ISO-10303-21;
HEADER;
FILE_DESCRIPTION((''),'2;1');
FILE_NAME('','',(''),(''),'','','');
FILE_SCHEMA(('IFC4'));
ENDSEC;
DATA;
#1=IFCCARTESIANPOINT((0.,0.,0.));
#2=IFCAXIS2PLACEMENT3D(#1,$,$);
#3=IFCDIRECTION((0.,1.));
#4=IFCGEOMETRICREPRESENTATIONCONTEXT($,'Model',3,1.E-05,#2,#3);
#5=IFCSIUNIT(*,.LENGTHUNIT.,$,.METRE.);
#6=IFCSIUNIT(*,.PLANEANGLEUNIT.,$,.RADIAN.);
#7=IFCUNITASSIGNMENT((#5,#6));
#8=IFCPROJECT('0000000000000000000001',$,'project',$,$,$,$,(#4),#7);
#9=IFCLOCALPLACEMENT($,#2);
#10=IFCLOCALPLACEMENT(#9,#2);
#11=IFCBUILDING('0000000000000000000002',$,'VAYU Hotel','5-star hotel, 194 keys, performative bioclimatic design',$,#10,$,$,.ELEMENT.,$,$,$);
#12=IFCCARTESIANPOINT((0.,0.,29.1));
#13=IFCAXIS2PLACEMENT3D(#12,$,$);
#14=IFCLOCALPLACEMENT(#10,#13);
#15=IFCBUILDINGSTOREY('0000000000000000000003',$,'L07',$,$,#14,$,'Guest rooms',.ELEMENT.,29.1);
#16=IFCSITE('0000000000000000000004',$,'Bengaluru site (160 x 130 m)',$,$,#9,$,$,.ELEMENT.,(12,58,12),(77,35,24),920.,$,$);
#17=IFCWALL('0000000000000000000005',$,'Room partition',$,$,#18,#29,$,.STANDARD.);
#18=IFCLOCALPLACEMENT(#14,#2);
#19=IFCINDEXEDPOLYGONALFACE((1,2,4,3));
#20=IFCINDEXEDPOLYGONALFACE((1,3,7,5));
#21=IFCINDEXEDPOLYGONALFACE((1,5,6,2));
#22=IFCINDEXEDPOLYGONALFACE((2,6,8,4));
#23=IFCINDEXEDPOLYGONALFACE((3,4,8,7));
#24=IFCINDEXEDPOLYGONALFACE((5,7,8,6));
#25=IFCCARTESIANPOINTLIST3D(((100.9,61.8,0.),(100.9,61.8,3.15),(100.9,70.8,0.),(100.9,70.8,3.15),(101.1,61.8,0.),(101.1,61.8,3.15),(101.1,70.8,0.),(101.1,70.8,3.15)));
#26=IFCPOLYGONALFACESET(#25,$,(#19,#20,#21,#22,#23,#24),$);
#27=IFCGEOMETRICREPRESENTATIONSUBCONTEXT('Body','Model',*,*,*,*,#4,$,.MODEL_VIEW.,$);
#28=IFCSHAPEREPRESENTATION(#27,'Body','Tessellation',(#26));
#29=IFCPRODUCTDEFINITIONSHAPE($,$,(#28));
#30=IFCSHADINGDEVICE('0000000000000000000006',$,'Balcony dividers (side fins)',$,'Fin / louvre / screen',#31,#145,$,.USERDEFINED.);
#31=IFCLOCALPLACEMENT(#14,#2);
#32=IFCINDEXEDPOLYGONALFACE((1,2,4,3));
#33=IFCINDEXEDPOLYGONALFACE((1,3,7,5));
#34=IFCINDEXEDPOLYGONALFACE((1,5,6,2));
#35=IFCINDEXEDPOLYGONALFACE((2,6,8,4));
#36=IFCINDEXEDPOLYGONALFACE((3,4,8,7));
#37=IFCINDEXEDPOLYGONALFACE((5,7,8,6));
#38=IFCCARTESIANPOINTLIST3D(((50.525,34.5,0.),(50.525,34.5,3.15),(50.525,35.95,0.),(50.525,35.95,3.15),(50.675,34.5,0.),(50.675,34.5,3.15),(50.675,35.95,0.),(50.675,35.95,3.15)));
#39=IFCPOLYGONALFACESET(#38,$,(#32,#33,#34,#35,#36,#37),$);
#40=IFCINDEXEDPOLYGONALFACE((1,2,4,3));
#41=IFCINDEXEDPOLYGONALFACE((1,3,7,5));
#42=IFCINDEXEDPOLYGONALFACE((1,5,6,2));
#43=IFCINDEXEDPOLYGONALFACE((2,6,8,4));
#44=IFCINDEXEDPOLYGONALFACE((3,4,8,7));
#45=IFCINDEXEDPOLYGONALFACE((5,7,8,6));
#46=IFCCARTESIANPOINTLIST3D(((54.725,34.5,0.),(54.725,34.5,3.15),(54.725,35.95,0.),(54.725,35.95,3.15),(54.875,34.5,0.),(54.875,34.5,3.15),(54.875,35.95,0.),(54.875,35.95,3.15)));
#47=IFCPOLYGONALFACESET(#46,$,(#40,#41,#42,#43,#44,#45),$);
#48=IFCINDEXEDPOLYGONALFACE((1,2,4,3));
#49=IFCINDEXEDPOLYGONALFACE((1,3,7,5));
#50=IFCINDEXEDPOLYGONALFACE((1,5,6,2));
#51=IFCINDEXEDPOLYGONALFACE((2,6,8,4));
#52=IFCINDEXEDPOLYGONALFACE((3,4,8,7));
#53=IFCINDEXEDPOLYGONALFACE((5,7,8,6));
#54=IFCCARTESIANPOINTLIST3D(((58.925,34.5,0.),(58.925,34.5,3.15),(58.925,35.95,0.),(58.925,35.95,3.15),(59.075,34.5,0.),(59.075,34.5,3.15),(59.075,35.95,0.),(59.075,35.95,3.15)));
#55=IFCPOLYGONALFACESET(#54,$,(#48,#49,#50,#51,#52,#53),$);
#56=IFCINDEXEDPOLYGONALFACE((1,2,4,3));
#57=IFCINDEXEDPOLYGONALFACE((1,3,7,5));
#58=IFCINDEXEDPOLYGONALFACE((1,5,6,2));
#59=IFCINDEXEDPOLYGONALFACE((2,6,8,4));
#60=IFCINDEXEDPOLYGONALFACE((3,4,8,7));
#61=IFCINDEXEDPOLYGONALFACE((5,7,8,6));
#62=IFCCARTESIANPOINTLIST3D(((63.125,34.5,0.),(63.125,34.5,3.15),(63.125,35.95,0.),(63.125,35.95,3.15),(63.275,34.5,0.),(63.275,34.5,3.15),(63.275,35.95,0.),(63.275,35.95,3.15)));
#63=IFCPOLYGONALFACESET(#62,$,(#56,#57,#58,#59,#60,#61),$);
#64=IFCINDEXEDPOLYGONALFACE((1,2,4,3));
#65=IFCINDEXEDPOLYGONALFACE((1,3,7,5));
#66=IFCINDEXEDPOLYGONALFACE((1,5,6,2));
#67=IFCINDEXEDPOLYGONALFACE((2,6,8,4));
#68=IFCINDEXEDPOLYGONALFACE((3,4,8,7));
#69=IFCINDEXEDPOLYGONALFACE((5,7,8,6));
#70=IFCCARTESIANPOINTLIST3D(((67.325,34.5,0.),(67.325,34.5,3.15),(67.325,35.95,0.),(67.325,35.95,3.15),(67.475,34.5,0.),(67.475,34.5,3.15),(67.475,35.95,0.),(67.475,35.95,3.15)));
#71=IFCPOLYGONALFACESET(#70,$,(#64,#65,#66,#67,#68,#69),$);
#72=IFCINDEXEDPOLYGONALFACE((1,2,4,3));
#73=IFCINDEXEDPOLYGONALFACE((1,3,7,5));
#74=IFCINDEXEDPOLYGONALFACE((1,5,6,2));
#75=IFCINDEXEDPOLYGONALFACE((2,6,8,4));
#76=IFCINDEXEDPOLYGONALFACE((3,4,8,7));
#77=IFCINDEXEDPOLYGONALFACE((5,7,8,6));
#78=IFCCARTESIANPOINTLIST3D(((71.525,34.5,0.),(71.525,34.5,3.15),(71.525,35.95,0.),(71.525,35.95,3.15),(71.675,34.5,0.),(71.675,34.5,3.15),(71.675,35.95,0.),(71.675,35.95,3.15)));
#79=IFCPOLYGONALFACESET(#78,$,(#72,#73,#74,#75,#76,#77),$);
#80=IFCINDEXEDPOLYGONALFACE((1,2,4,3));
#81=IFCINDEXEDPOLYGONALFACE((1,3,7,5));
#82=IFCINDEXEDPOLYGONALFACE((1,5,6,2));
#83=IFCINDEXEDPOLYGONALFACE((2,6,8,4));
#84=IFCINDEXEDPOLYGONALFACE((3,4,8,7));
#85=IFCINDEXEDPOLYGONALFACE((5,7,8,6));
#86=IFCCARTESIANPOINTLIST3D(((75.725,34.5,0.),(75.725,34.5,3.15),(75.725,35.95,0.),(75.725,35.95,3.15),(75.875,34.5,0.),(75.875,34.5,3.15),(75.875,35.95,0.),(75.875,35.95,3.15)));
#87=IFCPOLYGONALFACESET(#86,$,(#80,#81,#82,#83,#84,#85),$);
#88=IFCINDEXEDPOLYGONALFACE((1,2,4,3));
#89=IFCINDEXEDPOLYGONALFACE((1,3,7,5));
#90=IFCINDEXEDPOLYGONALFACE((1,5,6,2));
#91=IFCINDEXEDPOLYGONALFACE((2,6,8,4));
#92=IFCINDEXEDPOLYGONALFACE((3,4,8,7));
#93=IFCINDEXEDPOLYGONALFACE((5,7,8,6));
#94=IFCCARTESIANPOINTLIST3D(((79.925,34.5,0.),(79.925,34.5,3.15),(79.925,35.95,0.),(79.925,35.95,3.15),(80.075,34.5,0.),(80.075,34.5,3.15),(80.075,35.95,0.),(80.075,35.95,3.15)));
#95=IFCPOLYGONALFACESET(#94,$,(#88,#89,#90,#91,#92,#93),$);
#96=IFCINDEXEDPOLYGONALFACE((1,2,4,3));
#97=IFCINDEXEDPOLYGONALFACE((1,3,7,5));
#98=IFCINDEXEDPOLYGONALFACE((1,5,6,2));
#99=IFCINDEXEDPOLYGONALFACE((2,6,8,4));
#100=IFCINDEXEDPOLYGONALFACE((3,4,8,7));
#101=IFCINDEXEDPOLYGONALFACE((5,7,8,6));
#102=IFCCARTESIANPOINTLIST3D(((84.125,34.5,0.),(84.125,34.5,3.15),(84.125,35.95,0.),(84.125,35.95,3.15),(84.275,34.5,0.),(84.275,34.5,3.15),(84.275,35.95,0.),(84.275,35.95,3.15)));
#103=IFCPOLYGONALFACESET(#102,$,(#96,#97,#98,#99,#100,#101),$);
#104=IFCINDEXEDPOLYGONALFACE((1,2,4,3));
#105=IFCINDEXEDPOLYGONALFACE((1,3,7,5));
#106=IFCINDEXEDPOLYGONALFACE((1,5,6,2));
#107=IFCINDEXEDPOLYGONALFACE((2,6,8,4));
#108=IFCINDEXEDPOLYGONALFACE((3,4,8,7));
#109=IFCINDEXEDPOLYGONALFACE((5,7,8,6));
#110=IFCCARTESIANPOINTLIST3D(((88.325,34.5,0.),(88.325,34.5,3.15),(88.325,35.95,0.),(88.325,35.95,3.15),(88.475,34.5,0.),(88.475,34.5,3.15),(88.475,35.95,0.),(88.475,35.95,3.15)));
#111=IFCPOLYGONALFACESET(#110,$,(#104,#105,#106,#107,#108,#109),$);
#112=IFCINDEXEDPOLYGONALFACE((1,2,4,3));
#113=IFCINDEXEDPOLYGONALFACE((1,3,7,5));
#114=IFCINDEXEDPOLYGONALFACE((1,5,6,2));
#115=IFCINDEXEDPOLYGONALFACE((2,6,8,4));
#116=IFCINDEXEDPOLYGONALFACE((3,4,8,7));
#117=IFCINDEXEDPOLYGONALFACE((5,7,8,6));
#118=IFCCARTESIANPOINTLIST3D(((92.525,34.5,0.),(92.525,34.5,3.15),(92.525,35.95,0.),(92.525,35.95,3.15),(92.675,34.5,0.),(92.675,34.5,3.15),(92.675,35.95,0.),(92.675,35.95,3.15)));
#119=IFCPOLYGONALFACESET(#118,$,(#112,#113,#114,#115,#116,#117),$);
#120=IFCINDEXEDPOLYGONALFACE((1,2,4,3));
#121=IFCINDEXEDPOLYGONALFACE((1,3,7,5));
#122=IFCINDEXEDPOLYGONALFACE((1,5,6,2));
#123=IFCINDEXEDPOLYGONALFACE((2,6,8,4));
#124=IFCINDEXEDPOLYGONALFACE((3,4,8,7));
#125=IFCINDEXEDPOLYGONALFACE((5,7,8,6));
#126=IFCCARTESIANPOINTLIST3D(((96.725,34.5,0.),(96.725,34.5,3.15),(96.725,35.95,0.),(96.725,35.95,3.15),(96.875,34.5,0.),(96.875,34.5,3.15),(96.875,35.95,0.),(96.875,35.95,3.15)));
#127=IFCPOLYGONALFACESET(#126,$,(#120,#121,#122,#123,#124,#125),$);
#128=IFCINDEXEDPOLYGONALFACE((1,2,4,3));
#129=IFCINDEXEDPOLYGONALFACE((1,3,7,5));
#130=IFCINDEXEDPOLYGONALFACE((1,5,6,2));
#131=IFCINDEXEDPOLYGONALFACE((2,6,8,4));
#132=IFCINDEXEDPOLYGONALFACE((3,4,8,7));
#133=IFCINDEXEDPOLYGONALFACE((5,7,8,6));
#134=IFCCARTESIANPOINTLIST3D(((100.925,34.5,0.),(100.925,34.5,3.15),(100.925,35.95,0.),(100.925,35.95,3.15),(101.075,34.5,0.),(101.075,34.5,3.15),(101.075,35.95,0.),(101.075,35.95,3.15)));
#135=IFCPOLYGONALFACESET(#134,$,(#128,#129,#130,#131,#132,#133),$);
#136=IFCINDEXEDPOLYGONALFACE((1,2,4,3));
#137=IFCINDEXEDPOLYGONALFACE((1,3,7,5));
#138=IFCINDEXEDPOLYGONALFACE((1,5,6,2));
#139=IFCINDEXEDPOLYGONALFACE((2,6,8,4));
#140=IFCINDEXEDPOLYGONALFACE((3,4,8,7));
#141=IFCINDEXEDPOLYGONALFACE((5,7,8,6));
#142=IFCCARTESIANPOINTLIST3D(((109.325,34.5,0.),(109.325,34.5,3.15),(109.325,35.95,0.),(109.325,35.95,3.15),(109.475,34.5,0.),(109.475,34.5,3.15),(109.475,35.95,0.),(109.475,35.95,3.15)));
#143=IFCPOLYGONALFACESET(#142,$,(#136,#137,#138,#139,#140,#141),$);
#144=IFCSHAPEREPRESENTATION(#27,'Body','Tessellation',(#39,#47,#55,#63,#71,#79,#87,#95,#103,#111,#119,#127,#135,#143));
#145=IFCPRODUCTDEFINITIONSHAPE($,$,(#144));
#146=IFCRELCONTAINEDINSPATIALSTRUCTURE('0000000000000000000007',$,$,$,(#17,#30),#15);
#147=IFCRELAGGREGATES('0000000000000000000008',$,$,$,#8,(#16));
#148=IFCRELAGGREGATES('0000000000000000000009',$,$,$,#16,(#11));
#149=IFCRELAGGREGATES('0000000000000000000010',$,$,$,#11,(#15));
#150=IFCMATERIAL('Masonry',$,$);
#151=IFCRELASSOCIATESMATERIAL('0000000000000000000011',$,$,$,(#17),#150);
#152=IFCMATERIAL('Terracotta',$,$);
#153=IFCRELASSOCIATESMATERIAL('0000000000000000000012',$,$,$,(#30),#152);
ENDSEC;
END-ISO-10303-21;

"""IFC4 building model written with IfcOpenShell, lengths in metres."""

from ifc_helpers import new_model, si_unit, direction, frame, origin, place, context, subcontext, project, spatial, polyline, outline, extrude, material, element, save


model = new_model("IFC4")

# Units and contexts
model_context = context("Model", 3, precision=1e-05, world=origin(), true_north=direction((0.0, 1.0)))
body_context = subcontext(model_context, "Body", "Model", "MODEL_VIEW")
ifc_project = project(units=[si_unit("LENGTHUNIT", "METRE"), si_unit("PLANEANGLEUNIT", "RADIAN")], contexts=[model_context])

# Site, building, storey
site_placement = place(None, origin())
site = spatial("IfcSite", under=ifc_project, at=site_placement, Name="Bengaluru site (160 x 130 m)", CompositionType="ELEMENT", RefLatitude=(12, 58, 12), RefLongitude=(77, 35, 24), RefElevation=920.0)
building_placement = place(site_placement, origin())
building = spatial("IfcBuilding", under=site, at=building_placement, Name="VAYU Hotel", Description="5-star hotel, 194 keys, performative bioclimatic design", CompositionType="ELEMENT")
storey_placement = place(building_placement, frame((0.0, 0.0, 29.1)))
storey = spatial("IfcBuildingStorey", under=building, at=storey_placement, Name="L07", LongName="Guest rooms", CompositionType="ELEMENT", Elevation=29.1)

# Wall
ifc_material_1 = material(Name="Masonry")
wall_1_placement = place(storey_placement, origin())
element("IfcWall", 1, at=wall_1_placement, inside=storey, material=ifc_material_1, Name="Room partition", PredefinedType="STANDARD", context=body_context, shape_type="SweptSolid", body=[
    extrude(outline(polyline([(100.9, 61.8), (100.9, 70.8), (101.1, 70.8), (101.1, 61.8), (100.9, 61.8)])), origin(), (0.0, 0.0, 1.0), 3.15),
])

# Shading device
ifc_material_2 = material(Name="Terracotta")
shading_device_1_placement = place(storey_placement, origin())
element("IfcShadingDevice", 2, at=shading_device_1_placement, inside=storey, material=ifc_material_2, Name="Balcony dividers (side fins)", ObjectType="Fin / louvre / screen", PredefinedType="USERDEFINED", context=body_context, shape_type="SweptSolid", body=[
    extrude(outline(polyline([(50.525, 34.5), (50.675, 34.5), (50.675, 35.95), (50.525, 35.95), (50.525, 34.5)])), origin(), (0.0, 0.0, 1.0), 3.15),
    extrude(outline(polyline([(54.725, 34.5), (54.875, 34.5), (54.875, 35.95), (54.725, 35.95), (54.725, 34.5)])), origin(), (0.0, 0.0, 1.0), 3.15),
    extrude(outline(polyline([(58.925, 34.5), (59.075, 34.5), (59.075, 35.95), (58.925, 35.95), (58.925, 34.5)])), origin(), (0.0, 0.0, 1.0), 3.15),
    extrude(outline(polyline([(63.125, 34.5), (63.275, 34.5), (63.275, 35.95), (63.125, 35.95), (63.125, 34.5)])), origin(), (0.0, 0.0, 1.0), 3.15),
    extrude(outline(polyline([(67.325, 34.5), (67.475, 34.5), (67.475, 35.95), (67.325, 35.95), (67.325, 34.5)])), origin(), (0.0, 0.0, 1.0), 3.15),
    extrude(outline(polyline([(71.525, 34.5), (71.675, 34.5), (71.675, 35.95), (71.525, 35.95), (71.525, 34.5)])), origin(), (0.0, 0.0, 1.0), 3.15),
    extrude(outline(polyline([(75.725, 34.5), (75.875, 34.5), (75.875, 35.95), (75.725, 35.95), (75.725, 34.5)])), origin(), (0.0, 0.0, 1.0), 3.15),
    extrude(outline(polyline([(79.925, 34.5), (80.075, 34.5), (80.075, 35.95), (79.925, 35.95), (79.925, 34.5)])), origin(), (0.0, 0.0, 1.0), 3.15),
    extrude(outline(polyline([(84.125, 34.5), (84.275, 34.5), (84.275, 35.95), (84.125, 35.95), (84.125, 34.5)])), origin(), (0.0, 0.0, 1.0), 3.15),
    extrude(outline(polyline([(88.325, 34.5), (88.475, 34.5), (88.475, 35.95), (88.325, 35.95), (88.325, 34.5)])), origin(), (0.0, 0.0, 1.0), 3.15),
    extrude(outline(polyline([(92.525, 34.5), (92.675, 34.5), (92.675, 35.95), (92.525, 35.95), (92.525, 34.5)])), origin(), (0.0, 0.0, 1.0), 3.15),
    extrude(outline(polyline([(96.725, 34.5), (96.875, 34.5), (96.875, 35.95), (96.725, 35.95), (96.725, 34.5)])), origin(), (0.0, 0.0, 1.0), 3.15),
    extrude(outline(polyline([(100.925, 34.5), (101.075, 34.5), (101.075, 35.95), (100.925, 35.95), (100.925, 34.5)])), origin(), (0.0, 0.0, 1.0), 3.15),
    extrude(outline(polyline([(109.325, 34.5), (109.475, 34.5), (109.475, 35.95), (109.325, 35.95), (109.325, 34.5)])), origin(), (0.0, 0.0, 1.0), 3.15),
])

save(model, "model.ifc")
